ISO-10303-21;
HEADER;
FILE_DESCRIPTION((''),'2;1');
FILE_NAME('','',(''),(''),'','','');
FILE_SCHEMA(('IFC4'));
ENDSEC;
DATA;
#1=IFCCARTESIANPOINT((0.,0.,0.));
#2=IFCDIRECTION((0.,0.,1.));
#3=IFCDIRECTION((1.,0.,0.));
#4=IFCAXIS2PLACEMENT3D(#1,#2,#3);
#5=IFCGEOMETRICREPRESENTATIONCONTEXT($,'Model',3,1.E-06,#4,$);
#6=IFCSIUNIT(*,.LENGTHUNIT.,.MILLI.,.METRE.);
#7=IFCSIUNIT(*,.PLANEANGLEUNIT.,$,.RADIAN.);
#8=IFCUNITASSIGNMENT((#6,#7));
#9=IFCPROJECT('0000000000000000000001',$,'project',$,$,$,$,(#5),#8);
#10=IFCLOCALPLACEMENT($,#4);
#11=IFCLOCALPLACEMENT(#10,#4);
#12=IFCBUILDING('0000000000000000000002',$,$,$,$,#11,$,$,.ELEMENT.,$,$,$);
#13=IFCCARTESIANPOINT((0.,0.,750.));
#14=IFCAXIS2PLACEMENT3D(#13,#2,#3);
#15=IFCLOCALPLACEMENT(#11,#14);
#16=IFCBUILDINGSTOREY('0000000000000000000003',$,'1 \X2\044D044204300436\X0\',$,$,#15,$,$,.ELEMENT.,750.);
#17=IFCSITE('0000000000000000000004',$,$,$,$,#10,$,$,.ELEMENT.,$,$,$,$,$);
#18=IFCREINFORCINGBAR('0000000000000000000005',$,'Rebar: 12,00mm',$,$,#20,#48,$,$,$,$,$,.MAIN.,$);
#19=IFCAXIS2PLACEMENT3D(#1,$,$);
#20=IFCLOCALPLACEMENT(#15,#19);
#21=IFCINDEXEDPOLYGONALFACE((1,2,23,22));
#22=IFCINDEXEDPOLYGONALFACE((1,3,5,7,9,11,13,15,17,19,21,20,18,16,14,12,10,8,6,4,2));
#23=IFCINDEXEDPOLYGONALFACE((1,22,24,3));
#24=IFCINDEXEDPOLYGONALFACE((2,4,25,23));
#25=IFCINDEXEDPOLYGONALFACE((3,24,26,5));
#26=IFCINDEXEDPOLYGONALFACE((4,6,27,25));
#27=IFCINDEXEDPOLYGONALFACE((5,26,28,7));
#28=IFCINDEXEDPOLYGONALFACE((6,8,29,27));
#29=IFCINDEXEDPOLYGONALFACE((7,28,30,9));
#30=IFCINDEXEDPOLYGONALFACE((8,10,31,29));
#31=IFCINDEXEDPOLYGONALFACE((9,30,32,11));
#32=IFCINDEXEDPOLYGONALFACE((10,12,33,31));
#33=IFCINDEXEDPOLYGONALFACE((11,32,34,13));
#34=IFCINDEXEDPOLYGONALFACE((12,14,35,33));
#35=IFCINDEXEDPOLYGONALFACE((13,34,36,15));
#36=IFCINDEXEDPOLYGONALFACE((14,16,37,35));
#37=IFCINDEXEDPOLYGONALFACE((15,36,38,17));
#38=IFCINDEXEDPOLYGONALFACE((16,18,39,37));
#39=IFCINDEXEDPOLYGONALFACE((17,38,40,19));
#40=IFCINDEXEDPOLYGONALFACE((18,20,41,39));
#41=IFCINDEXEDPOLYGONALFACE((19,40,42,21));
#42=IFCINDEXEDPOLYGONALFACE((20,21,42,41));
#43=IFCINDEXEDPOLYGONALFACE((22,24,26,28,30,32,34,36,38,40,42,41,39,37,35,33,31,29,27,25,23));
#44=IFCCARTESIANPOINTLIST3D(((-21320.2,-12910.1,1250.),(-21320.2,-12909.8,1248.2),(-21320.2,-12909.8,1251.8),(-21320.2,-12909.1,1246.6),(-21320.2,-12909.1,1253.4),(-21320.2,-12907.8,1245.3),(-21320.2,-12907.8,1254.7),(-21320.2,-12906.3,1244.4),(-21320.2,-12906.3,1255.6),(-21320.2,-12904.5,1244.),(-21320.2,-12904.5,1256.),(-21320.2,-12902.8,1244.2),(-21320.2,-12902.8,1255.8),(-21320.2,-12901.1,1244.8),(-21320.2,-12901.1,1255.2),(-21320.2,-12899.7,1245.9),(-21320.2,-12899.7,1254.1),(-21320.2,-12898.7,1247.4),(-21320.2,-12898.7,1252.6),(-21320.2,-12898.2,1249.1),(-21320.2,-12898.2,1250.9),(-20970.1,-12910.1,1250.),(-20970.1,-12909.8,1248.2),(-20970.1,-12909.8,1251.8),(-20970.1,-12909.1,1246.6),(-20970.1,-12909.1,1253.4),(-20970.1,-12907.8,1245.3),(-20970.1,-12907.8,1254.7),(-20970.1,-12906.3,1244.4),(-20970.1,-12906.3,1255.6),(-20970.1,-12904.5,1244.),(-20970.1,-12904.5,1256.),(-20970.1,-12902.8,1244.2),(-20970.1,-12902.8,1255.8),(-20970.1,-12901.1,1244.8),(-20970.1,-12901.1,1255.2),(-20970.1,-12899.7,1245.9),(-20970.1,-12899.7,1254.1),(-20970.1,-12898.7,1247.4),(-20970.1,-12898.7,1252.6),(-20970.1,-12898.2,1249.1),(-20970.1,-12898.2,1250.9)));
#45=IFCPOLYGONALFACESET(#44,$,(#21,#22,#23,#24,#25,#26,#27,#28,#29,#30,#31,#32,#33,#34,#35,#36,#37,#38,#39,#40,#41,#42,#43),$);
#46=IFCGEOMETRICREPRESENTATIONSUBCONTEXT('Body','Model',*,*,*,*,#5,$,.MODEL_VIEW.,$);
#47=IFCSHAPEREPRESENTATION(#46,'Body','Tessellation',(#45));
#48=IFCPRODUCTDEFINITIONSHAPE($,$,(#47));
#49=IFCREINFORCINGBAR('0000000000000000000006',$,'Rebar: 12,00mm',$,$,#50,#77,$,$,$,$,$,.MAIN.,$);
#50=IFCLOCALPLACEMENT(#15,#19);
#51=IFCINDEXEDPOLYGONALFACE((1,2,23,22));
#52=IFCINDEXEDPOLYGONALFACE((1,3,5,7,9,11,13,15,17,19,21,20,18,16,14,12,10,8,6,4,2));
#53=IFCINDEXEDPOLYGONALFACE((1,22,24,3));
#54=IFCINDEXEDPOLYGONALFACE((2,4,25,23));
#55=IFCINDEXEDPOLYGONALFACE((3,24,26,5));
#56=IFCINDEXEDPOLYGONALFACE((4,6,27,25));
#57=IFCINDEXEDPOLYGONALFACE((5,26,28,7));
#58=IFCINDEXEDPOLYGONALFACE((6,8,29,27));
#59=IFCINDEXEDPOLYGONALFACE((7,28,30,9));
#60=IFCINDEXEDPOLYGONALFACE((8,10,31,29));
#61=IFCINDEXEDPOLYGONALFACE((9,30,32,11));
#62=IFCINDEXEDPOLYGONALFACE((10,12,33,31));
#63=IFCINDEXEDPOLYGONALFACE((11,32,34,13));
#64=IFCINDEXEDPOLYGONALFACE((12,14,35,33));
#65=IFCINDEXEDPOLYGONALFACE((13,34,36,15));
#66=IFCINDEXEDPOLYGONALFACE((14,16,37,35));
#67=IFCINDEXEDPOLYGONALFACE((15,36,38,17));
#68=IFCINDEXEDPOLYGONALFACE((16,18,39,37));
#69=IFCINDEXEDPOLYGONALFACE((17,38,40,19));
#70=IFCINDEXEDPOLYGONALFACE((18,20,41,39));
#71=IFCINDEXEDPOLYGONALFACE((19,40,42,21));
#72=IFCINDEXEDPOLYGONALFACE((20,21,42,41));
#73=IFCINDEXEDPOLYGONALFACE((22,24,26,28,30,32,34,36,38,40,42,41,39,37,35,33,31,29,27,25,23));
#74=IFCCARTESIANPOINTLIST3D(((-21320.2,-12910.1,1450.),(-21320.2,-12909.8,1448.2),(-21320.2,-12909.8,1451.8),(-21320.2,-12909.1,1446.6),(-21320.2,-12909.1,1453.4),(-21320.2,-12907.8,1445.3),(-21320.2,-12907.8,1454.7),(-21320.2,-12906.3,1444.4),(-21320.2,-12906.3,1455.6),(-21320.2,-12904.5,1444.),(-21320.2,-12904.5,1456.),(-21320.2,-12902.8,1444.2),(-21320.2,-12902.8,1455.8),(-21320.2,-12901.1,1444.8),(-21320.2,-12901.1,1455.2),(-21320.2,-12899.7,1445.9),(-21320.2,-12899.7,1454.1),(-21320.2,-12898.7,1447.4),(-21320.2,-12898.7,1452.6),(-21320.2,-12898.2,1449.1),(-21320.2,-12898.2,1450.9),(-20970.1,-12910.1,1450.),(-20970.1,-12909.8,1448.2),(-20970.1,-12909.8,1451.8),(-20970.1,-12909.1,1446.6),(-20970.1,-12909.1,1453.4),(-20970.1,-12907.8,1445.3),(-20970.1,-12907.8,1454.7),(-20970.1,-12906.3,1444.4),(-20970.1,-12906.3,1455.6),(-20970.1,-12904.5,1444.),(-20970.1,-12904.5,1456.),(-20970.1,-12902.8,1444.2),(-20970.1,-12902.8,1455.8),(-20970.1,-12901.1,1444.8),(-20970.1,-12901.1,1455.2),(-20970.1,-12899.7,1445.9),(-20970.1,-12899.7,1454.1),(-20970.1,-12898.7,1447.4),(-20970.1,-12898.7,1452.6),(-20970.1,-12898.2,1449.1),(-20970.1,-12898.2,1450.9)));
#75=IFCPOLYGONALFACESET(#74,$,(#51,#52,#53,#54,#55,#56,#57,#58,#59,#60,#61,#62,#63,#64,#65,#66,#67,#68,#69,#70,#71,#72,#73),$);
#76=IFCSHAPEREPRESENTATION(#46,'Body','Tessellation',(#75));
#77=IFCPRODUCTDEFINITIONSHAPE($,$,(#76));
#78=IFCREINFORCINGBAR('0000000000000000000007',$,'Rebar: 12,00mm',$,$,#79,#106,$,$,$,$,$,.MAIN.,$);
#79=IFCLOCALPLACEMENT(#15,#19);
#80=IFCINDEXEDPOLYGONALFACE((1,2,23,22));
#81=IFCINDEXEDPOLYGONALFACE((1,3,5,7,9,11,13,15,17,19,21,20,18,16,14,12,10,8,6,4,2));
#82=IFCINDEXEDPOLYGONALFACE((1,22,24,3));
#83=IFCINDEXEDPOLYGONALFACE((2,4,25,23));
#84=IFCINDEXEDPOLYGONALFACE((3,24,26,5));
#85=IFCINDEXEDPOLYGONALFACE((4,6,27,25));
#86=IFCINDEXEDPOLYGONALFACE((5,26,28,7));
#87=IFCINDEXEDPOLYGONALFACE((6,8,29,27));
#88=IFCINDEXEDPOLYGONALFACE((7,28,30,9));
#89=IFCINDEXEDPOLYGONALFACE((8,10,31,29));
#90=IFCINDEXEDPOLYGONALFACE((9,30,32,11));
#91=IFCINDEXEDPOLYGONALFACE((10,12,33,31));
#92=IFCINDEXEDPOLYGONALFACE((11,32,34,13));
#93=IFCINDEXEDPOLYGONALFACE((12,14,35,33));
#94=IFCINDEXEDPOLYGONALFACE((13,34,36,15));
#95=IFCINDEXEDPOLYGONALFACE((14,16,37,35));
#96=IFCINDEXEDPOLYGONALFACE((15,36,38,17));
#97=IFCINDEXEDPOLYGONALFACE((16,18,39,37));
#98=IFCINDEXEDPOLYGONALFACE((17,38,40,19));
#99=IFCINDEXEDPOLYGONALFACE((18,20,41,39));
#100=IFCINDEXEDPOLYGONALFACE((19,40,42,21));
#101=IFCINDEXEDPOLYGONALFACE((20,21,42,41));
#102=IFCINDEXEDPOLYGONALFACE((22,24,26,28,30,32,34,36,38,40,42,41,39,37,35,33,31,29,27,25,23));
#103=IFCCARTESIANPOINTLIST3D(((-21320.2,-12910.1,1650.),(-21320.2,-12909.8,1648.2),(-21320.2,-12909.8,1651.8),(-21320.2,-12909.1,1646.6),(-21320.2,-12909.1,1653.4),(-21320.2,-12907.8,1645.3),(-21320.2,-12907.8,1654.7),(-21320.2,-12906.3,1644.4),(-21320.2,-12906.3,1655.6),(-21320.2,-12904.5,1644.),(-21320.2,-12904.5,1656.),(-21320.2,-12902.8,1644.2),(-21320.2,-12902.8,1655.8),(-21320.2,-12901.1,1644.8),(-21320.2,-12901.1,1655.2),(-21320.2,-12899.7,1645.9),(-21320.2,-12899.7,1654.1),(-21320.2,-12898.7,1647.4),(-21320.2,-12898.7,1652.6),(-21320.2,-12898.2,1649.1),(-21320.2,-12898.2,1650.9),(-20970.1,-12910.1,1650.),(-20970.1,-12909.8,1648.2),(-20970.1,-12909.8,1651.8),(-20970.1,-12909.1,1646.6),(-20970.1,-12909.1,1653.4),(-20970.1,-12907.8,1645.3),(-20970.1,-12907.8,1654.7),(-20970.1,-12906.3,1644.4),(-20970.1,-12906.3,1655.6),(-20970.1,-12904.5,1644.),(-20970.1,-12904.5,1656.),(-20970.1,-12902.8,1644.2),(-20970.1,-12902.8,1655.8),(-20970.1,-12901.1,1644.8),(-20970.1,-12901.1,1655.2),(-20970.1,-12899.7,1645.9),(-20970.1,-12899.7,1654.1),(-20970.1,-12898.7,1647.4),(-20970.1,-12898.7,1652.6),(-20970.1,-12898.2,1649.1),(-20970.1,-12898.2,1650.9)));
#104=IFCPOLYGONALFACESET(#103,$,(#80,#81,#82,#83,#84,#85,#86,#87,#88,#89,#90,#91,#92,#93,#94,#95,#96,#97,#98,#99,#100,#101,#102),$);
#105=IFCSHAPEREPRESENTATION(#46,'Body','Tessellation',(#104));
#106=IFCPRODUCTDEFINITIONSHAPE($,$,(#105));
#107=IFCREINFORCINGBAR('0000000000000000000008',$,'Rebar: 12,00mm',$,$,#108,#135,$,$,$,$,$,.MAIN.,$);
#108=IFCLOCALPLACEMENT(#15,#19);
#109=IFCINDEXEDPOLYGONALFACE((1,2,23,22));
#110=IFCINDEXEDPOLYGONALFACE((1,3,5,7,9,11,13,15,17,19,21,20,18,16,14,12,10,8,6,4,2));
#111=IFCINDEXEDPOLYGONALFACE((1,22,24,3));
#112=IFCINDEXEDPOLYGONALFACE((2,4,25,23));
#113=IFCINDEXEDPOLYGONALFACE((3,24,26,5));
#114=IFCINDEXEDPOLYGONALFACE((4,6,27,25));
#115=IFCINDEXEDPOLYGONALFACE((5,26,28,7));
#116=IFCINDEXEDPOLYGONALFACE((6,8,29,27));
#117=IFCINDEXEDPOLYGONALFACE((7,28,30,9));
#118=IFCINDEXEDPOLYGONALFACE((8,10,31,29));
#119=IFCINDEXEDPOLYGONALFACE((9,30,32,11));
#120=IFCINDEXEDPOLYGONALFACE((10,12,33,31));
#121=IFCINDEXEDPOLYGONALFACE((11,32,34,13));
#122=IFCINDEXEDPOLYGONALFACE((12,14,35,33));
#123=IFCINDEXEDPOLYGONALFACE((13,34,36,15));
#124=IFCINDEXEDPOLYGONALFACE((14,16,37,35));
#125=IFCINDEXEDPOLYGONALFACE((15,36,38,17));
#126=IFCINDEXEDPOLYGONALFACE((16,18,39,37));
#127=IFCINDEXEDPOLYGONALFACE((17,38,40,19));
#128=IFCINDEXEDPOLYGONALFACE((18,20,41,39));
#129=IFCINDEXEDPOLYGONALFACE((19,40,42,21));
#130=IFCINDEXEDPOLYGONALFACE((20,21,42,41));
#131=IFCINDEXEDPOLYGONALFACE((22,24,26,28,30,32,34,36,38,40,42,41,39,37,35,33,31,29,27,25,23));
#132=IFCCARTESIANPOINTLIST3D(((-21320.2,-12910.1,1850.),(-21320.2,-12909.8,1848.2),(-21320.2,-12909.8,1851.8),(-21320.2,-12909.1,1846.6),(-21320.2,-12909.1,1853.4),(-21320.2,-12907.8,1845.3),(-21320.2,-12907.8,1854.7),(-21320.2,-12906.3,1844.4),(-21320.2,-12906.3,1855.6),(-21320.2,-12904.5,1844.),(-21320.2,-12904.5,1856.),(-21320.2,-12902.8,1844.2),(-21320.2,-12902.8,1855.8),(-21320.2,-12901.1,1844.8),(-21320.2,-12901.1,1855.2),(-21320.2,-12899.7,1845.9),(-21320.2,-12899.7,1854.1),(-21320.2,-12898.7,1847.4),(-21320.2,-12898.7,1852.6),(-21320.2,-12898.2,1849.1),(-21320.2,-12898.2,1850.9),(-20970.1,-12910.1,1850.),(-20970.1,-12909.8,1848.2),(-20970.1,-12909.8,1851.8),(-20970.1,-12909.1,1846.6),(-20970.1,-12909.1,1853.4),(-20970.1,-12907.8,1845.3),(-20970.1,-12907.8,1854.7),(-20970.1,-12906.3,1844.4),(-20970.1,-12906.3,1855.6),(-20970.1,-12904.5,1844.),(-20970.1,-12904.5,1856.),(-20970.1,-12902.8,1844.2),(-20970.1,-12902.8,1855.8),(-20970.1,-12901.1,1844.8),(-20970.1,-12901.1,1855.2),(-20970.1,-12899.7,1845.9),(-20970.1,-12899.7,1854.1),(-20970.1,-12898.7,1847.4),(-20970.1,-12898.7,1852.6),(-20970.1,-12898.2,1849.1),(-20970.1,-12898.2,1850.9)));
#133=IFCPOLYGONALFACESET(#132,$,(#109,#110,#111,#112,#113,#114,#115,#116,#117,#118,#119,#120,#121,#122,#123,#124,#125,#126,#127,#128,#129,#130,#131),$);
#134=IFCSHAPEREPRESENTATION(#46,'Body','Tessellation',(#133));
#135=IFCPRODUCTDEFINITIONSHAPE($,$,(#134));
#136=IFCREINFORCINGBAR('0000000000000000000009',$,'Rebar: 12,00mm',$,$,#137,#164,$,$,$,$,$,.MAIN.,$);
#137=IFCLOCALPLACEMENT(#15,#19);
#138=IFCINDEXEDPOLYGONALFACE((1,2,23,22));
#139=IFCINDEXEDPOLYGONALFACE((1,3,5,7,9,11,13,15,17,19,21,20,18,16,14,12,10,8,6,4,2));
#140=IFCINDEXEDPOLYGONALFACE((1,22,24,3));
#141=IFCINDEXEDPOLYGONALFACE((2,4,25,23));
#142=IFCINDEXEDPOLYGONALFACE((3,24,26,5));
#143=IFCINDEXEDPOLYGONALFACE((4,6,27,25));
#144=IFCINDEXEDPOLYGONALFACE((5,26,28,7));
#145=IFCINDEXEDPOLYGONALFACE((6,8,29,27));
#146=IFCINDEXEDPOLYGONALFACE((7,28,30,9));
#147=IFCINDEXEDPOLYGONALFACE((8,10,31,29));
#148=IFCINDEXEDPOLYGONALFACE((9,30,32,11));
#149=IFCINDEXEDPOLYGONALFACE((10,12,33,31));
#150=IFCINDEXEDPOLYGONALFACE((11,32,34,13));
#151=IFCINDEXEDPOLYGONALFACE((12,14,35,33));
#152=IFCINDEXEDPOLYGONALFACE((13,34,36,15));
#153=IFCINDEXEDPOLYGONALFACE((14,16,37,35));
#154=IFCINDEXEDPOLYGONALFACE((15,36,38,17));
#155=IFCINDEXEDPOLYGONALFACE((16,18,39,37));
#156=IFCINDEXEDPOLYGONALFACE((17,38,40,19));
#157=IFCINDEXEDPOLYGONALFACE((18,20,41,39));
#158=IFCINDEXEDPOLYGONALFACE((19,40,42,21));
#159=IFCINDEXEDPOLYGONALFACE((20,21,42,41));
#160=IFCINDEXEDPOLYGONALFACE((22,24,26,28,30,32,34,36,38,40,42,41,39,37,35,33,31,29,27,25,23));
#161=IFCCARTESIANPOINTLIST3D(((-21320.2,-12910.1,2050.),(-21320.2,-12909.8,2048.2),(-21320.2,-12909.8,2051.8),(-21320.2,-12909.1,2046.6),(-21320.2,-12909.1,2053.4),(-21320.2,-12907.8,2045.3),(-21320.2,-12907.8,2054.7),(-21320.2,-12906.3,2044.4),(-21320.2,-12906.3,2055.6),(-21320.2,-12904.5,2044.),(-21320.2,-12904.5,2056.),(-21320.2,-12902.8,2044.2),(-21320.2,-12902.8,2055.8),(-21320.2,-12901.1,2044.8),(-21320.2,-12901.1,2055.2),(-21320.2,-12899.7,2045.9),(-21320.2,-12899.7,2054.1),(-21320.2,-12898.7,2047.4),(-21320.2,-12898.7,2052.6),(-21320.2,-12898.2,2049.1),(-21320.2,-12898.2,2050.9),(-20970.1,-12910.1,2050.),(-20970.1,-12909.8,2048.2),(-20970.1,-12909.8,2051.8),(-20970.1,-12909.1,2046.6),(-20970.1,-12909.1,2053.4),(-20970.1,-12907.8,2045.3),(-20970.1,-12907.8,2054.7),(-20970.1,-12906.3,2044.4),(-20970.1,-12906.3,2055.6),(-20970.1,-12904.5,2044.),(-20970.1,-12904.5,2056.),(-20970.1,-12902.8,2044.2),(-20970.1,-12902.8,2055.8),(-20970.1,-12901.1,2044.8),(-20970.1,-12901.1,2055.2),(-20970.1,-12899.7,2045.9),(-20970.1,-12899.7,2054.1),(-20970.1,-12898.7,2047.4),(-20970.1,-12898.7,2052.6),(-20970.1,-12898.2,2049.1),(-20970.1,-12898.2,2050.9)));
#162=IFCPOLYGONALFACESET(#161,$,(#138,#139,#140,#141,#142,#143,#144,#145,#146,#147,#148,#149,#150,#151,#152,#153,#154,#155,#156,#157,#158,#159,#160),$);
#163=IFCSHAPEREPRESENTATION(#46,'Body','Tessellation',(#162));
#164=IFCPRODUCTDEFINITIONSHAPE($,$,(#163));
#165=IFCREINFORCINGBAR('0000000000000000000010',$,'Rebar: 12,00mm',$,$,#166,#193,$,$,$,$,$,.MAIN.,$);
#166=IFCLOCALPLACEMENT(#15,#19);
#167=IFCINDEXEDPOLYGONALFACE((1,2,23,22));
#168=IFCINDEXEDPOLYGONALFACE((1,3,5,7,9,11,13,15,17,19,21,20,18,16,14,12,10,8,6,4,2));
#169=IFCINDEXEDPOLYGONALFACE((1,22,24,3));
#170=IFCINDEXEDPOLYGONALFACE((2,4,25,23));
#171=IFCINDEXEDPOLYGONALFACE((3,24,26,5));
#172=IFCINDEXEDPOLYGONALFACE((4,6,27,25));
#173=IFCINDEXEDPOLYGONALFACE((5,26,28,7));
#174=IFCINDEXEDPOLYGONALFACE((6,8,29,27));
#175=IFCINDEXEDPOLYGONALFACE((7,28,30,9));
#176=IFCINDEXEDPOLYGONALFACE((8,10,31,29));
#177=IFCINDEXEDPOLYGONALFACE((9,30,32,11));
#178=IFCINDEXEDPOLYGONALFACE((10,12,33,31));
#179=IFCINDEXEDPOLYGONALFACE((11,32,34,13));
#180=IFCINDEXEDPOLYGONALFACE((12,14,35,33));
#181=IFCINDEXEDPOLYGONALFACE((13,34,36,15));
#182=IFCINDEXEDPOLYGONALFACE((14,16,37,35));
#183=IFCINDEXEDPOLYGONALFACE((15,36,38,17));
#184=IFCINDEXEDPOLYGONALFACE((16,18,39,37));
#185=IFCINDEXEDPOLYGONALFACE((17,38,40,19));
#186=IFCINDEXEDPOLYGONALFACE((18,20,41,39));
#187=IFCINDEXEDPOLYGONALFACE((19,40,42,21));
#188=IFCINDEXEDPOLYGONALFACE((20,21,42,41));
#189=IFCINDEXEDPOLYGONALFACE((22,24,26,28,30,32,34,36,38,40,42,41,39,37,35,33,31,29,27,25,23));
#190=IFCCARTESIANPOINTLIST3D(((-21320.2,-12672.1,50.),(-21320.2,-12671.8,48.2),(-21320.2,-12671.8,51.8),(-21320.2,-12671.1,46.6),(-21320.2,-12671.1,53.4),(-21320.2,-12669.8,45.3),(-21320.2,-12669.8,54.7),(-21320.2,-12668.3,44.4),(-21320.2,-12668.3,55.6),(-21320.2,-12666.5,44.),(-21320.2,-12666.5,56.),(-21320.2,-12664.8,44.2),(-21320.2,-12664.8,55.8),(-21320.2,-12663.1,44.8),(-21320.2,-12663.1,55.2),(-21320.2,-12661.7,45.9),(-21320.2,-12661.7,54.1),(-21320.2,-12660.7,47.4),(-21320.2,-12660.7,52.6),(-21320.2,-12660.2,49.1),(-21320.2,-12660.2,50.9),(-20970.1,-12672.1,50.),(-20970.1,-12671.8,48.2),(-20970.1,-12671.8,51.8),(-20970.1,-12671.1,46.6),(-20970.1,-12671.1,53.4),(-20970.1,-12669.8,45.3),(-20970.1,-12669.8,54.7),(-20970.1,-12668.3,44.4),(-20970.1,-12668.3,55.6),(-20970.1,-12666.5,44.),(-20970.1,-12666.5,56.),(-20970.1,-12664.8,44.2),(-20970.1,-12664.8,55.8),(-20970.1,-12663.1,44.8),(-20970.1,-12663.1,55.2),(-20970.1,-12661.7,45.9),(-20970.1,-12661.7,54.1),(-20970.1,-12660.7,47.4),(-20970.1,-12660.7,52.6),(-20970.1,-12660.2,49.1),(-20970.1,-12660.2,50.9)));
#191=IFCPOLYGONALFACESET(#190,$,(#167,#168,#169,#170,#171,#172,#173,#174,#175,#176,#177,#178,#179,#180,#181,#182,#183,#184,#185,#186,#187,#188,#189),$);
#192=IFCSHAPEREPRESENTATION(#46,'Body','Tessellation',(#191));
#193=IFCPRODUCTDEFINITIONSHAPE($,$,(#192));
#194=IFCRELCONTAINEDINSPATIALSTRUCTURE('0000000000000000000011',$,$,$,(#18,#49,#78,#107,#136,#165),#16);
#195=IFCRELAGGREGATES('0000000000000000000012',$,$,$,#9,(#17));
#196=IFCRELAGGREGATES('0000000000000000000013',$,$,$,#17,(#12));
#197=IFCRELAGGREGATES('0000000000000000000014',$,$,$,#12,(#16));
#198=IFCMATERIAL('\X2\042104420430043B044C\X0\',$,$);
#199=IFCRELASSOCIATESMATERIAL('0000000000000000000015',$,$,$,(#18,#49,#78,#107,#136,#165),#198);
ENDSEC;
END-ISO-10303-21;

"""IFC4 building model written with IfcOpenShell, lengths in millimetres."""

from ifc_helpers import new_model, entity, si_unit, frame, origin_with_axes, place, context, subcontext, project, spatial, source, transform, mapped, material, element, save


model = new_model("IFC4")

# Units and contexts
model_context = context("Model", 3, precision=1e-06, world=origin_with_axes())
body_context = subcontext(model_context, "Body", "Model", "MODEL_VIEW")
ifc_project = project(units=[si_unit("LENGTHUNIT", "METRE", prefix="MILLI"), si_unit("PLANEANGLEUNIT", "RADIAN")], contexts=[model_context])

# Site, building, storey
site_placement = place(None, origin_with_axes())
site = spatial("IfcSite", under=ifc_project, at=site_placement, CompositionType="ELEMENT")
building_placement = place(site_placement, origin_with_axes())
building = spatial("IfcBuilding", under=site, at=building_placement, CompositionType="ELEMENT")
storey_placement = place(building_placement, frame((0.0, 0.0, 750.0), z_axis=(0.0, 0.0, 1.0), x_axis=(1.0, 0.0, 0.0)))
storey = spatial("IfcBuildingStorey", under=building, at=storey_placement, Name="1 этаж", CompositionType="ELEMENT", Elevation=750.0)

# Reinforcing bars
ifc_material = material(Name="Сталь")
shared_shape_1 = source(origin_with_axes(), body_context, "Body", "AdvancedSweptSolid", [
    entity("IfcSweptDiskSolid", entity("IfcIndexedPolyCurve", entity("IfcCartesianPointList3D", [[0.0, 0.0, 0.0], [350.1, 0.0, 0.0]]), [entity("IfcLineIndex", [1, 2])]), 6.0),
])
reinforcing_bar_1_placement = place(storey_placement, origin_with_axes())
element("IfcReinforcingBar", 1, at=reinforcing_bar_1_placement, inside=storey, material=ifc_material, Name="Rebar: 12,00mm", PredefinedType="MAIN", context=body_context, shape_type="MappedRepresentation", body=[
    mapped(shared_shape_1, transform((-20970.1, -12904.1, 1250.0), x_axis=(-1.0, 0.0, 0.0), y_axis=(0.0, -1.0, 0.0), z_axis=(0.0, 0.0, 1.0), scale=1.0)),
])
reinforcing_bar_2_placement = place(storey_placement, origin_with_axes())
element("IfcReinforcingBar", 2, at=reinforcing_bar_2_placement, inside=storey, material=ifc_material, Name="Rebar: 12,00mm", PredefinedType="MAIN", context=body_context, shape_type="MappedRepresentation", body=[
    mapped(shared_shape_1, transform((-20970.1, -12904.1, 1450.0), x_axis=(-1.0, 0.0, 0.0), y_axis=(0.0, -1.0, 0.0), z_axis=(0.0, 0.0, 1.0), scale=1.0)),
])
reinforcing_bar_3_placement = place(storey_placement, origin_with_axes())
element("IfcReinforcingBar", 3, at=reinforcing_bar_3_placement, inside=storey, material=ifc_material, Name="Rebar: 12,00mm", PredefinedType="MAIN", context=body_context, shape_type="MappedRepresentation", body=[
    mapped(shared_shape_1, transform((-20970.1, -12904.1, 1650.0), x_axis=(-1.0, 0.0, 0.0), y_axis=(0.0, -1.0, 0.0), z_axis=(0.0, 0.0, 1.0), scale=1.0)),
])
reinforcing_bar_4_placement = place(storey_placement, origin_with_axes())
element("IfcReinforcingBar", 4, at=reinforcing_bar_4_placement, inside=storey, material=ifc_material, Name="Rebar: 12,00mm", PredefinedType="MAIN", context=body_context, shape_type="MappedRepresentation", body=[
    mapped(shared_shape_1, transform((-20970.1, -12904.1, 1850.0), x_axis=(-1.0, 0.0, 0.0), y_axis=(0.0, -1.0, 0.0), z_axis=(0.0, 0.0, 1.0), scale=1.0)),
])
reinforcing_bar_5_placement = place(storey_placement, origin_with_axes())
element("IfcReinforcingBar", 5, at=reinforcing_bar_5_placement, inside=storey, material=ifc_material, Name="Rebar: 12,00mm", PredefinedType="MAIN", context=body_context, shape_type="MappedRepresentation", body=[
    mapped(shared_shape_1, transform((-20970.1, -12904.1, 2050.0), x_axis=(-1.0, 0.0, 0.0), y_axis=(0.0, -1.0, 0.0), z_axis=(0.0, 0.0, 1.0), scale=1.0)),
])
reinforcing_bar_6_placement = place(storey_placement, origin_with_axes())
element("IfcReinforcingBar", 6, at=reinforcing_bar_6_placement, inside=storey, material=ifc_material, Name="Rebar: 12,00mm", PredefinedType="MAIN", context=body_context, shape_type="MappedRepresentation", body=[
    mapped(shared_shape_1, transform((-20970.1, -12666.1, 50.0), x_axis=(-1.0, 0.0, 0.0), y_axis=(0.0, -1.0, 0.0), z_axis=(0.0, 0.0, 1.0), scale=1.0)),
])

save(model, "model.ifc")
